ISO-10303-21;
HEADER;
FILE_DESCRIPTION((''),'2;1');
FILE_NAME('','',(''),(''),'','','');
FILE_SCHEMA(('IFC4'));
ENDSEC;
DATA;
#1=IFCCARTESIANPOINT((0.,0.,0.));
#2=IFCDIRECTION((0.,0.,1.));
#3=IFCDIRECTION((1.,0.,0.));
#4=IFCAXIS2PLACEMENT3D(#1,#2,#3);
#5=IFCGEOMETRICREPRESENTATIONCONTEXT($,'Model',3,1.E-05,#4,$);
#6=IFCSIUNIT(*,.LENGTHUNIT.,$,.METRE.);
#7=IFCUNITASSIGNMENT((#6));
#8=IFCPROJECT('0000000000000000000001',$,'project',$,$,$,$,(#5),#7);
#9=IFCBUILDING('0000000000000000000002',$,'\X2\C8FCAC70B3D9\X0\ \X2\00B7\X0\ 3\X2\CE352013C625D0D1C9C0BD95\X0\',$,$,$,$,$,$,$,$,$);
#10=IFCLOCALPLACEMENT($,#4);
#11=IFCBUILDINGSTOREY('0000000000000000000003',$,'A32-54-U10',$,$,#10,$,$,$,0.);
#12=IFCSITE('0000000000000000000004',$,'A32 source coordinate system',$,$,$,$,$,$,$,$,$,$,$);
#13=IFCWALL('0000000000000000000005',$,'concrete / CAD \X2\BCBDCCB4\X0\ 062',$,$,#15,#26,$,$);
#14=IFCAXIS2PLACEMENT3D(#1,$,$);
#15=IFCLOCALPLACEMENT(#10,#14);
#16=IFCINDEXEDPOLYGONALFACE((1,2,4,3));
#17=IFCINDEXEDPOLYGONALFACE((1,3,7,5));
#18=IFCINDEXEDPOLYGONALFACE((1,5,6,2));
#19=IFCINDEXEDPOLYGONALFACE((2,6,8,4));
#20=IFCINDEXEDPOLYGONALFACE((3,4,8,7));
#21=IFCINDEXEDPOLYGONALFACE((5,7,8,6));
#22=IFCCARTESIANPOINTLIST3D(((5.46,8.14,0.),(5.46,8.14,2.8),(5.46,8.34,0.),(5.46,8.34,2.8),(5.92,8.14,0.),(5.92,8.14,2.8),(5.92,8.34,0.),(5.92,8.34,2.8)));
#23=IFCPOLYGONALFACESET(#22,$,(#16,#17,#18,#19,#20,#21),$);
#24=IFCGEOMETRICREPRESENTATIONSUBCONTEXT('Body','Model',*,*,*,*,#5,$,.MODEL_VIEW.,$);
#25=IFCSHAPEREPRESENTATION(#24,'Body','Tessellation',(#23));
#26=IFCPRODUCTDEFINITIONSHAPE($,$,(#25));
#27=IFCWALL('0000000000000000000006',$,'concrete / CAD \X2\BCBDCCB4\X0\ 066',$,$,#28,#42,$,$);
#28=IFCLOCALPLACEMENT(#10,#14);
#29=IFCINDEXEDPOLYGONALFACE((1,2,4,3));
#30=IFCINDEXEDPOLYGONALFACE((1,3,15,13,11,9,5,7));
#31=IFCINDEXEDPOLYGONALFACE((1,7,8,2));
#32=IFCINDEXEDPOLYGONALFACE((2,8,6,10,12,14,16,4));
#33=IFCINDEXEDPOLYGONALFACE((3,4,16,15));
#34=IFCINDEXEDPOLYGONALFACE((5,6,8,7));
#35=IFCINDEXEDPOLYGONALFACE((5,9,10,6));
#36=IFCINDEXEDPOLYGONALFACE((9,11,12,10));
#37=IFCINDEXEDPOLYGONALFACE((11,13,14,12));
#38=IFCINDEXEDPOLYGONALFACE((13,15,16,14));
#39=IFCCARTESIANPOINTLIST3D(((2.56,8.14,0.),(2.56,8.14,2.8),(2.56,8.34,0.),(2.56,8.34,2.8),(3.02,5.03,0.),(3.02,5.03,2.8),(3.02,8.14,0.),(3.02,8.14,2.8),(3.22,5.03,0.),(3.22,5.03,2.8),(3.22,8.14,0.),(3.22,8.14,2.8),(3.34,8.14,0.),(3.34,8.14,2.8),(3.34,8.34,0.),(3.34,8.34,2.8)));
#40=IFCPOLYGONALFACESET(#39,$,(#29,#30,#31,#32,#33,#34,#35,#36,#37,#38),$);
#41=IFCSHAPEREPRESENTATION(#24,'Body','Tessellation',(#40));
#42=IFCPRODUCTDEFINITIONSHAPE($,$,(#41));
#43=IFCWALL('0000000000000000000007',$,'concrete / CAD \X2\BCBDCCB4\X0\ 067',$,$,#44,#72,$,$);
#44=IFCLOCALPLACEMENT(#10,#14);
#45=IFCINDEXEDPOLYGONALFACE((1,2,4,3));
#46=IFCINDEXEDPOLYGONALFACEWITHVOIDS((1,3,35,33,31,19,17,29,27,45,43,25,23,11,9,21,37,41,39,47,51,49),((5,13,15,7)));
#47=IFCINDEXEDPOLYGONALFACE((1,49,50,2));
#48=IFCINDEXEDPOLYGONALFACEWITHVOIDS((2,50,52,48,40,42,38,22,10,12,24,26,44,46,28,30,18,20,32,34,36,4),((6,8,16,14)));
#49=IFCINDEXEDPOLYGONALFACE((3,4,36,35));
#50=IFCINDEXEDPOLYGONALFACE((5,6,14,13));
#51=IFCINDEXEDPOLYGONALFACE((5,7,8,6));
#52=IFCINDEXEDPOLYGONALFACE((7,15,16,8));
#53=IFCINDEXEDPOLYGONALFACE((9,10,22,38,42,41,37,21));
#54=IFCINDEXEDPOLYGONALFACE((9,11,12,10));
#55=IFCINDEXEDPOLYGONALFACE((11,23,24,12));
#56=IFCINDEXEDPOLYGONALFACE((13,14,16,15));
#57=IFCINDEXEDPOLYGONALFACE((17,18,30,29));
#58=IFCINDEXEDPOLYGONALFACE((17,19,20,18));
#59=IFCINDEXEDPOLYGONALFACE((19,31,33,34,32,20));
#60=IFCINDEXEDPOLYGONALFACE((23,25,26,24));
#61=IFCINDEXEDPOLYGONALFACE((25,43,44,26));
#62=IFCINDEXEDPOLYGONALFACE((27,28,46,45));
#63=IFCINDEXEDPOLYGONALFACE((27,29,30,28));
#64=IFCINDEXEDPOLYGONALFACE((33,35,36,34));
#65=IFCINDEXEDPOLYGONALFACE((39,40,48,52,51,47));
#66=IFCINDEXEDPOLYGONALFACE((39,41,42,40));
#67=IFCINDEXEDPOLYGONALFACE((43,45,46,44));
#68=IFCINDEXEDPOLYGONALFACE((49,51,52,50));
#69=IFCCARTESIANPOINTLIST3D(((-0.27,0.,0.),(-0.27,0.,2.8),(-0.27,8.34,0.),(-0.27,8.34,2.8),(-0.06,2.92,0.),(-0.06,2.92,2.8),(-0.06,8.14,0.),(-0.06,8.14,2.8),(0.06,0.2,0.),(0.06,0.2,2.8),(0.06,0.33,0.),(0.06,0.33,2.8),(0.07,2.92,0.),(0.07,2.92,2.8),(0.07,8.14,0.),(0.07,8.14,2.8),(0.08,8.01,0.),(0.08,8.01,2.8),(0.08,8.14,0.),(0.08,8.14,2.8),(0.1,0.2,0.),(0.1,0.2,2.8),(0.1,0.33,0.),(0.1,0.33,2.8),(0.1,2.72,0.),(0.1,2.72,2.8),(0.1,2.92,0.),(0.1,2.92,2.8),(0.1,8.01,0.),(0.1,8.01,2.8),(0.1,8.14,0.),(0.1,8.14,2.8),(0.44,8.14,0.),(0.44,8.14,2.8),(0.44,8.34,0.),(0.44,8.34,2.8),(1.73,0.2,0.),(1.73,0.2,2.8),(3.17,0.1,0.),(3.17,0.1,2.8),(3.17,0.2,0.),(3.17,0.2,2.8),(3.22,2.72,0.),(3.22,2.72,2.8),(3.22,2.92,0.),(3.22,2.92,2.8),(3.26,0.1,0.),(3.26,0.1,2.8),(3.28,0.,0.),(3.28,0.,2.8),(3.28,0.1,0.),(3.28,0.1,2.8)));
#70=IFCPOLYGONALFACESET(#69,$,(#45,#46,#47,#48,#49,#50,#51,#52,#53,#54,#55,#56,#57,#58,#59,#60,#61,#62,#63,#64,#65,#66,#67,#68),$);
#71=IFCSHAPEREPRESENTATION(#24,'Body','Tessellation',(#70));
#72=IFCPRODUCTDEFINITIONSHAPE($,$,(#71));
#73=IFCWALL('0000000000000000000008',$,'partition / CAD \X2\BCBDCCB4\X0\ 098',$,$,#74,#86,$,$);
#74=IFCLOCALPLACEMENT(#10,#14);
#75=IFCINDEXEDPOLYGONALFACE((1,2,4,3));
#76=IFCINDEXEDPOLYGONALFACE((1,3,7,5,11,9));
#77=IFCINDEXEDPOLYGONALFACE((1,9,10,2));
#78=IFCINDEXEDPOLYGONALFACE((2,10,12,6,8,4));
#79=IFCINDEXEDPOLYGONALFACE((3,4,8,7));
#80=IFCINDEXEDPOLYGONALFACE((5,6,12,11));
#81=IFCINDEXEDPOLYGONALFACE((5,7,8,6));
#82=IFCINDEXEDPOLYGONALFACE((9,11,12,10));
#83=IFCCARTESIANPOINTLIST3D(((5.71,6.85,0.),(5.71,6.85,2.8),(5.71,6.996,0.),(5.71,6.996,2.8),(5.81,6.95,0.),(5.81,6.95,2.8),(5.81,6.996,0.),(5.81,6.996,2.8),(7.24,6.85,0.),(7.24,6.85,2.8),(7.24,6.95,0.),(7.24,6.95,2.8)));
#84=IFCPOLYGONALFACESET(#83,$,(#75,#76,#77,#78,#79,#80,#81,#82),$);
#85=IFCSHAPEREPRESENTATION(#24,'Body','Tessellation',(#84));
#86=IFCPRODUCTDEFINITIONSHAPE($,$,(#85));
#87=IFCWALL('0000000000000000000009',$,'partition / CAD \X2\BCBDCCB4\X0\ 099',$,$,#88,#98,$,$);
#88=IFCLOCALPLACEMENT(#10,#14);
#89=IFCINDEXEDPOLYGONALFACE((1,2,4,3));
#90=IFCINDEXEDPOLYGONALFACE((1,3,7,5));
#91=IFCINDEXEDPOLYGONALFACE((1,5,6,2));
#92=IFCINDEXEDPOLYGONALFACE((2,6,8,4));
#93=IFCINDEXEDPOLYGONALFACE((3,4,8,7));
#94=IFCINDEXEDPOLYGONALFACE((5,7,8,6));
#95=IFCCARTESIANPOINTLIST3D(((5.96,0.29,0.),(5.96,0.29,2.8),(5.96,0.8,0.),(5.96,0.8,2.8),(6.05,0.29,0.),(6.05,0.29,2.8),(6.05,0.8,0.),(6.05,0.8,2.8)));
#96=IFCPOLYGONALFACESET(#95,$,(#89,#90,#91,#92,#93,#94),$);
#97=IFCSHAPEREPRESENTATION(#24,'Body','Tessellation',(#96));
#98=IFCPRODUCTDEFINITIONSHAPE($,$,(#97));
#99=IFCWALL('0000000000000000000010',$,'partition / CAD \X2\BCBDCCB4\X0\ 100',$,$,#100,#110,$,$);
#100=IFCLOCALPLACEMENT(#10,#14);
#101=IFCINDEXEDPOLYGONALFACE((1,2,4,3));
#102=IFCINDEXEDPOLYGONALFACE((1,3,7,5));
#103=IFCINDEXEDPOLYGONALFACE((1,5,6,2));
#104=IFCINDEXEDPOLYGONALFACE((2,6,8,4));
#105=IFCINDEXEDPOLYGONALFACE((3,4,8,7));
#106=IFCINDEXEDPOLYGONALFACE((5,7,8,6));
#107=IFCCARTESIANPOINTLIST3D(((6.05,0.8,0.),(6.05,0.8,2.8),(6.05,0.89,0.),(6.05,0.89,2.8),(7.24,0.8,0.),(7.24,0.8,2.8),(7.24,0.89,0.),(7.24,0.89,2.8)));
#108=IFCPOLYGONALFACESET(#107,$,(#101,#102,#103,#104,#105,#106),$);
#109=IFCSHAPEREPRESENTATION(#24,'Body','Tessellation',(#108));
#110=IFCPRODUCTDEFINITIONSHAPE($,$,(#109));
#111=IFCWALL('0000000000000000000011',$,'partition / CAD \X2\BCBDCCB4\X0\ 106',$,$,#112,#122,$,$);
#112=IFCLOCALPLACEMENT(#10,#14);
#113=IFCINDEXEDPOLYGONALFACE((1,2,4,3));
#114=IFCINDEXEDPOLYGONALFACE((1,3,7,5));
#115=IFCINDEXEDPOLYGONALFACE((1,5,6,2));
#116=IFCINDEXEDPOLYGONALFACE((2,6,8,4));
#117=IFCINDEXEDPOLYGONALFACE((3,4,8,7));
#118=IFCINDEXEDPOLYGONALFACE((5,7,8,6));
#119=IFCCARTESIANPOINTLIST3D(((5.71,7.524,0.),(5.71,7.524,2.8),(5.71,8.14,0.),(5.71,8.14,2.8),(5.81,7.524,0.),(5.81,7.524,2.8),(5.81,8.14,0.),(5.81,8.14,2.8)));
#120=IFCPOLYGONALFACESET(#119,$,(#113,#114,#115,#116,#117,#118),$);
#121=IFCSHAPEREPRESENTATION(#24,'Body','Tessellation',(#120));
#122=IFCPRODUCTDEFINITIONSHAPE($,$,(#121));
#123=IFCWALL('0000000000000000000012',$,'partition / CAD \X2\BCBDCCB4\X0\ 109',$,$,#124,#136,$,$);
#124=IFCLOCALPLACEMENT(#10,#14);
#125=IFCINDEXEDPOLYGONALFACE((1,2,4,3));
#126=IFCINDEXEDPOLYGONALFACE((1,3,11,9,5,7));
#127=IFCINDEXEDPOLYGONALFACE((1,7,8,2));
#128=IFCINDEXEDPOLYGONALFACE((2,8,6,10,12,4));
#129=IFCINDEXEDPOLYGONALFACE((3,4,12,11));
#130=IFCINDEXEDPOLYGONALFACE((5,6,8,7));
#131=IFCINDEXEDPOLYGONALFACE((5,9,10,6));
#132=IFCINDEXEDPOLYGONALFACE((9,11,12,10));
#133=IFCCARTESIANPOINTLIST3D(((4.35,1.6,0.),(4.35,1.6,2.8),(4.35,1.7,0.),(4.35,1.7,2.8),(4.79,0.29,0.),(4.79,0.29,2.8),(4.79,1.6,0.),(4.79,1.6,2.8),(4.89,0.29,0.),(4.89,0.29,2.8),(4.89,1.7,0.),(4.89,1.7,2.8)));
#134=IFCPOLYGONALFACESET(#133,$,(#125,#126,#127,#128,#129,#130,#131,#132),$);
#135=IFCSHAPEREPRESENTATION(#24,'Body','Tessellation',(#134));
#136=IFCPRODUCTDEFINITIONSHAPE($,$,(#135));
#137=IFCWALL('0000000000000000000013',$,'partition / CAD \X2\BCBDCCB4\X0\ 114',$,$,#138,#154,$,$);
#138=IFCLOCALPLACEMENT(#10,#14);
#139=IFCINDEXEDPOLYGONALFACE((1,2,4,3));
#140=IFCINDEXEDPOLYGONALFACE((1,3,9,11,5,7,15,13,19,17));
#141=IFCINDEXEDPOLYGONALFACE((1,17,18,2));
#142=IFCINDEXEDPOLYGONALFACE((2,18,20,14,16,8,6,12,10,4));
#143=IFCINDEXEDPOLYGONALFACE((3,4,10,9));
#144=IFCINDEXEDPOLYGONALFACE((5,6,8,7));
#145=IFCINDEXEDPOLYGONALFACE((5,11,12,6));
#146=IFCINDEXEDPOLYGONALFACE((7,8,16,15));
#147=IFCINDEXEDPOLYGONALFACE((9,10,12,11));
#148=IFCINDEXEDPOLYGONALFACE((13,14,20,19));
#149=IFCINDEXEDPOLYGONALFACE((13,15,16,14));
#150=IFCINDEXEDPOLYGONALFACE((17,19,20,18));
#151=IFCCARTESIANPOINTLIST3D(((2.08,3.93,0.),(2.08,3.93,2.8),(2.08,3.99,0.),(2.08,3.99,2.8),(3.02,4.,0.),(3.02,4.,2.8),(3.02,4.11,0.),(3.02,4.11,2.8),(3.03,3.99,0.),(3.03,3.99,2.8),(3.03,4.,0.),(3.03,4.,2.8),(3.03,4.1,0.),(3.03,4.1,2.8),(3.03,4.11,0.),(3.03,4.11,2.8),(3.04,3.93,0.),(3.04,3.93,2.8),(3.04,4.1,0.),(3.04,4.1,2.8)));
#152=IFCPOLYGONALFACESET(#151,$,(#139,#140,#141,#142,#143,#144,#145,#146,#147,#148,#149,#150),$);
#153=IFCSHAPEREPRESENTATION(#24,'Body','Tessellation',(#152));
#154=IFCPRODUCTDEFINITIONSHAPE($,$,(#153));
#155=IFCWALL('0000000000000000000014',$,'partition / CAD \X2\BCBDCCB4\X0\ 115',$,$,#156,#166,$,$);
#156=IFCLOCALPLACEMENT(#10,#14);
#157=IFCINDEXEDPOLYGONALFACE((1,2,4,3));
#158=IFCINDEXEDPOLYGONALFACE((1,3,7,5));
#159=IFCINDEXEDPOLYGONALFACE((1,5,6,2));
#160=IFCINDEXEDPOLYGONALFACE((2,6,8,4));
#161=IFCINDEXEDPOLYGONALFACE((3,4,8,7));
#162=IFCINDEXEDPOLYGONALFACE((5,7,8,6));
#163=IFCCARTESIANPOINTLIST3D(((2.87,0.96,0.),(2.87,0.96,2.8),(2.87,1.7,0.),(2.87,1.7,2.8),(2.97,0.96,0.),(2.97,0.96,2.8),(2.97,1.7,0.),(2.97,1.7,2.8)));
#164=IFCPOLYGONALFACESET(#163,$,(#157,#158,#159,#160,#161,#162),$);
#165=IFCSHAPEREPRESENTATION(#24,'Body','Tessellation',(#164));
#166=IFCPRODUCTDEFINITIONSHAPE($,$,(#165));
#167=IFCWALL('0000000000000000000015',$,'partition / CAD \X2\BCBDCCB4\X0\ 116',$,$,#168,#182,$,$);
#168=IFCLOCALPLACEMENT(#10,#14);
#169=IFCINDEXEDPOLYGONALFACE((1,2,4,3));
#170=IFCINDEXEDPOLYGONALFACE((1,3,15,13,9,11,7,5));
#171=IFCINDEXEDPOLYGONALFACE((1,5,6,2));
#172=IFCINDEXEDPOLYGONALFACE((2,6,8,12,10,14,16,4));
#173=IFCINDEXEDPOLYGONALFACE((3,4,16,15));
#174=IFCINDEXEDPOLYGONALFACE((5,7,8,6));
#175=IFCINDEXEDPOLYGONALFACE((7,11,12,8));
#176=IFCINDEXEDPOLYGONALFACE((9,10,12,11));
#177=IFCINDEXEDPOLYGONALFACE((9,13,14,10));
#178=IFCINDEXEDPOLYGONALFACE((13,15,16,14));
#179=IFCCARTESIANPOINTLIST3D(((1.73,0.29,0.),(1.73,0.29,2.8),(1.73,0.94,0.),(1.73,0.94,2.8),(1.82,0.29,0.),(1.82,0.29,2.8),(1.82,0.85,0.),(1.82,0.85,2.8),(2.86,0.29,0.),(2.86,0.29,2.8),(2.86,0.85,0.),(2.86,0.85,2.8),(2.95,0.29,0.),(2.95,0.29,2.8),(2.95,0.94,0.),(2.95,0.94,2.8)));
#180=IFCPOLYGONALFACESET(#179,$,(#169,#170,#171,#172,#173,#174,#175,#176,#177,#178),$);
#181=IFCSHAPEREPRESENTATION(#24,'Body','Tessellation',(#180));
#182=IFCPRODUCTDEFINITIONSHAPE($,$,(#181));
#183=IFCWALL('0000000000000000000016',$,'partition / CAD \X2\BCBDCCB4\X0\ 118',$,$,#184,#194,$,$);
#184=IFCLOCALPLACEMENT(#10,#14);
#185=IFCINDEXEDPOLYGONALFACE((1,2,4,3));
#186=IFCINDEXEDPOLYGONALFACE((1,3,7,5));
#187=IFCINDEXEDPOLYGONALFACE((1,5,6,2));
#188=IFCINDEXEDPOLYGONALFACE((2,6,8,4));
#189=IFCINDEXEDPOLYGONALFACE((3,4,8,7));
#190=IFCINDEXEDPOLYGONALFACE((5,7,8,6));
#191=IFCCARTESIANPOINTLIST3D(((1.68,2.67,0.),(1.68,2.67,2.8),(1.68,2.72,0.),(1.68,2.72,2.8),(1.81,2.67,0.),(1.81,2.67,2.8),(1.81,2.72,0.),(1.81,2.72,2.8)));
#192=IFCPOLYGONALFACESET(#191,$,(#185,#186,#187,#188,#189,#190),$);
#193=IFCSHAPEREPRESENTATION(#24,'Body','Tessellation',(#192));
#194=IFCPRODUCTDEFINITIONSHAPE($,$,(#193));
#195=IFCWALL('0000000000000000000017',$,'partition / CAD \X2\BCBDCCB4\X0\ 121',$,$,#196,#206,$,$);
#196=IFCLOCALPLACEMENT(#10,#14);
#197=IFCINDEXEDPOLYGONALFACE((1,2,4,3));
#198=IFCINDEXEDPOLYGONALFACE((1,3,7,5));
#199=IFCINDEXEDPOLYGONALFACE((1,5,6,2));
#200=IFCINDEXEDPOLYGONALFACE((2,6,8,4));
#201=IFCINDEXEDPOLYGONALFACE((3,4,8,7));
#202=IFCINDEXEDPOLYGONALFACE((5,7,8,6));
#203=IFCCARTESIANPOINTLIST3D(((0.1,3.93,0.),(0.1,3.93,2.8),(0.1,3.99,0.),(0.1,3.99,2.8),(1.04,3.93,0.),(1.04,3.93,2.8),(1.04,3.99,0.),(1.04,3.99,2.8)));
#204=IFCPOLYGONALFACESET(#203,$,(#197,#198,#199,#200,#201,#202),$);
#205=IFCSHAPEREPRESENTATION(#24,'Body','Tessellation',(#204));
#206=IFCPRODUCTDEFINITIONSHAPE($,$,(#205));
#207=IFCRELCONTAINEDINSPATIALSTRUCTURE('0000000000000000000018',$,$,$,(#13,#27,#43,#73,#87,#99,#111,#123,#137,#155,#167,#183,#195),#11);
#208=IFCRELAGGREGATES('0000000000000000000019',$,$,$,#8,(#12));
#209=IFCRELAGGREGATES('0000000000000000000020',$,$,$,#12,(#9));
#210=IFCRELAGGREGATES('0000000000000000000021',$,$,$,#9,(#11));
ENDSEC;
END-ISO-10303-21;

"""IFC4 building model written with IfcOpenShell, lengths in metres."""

from ifc_helpers import new_model, si_unit, origin, origin_with_axes, place, context, subcontext, project, spatial, polyline, outline, extrude, element, save


model = new_model("IFC4")

# Units and contexts
model_context = context("Model", 3, precision=1e-05, world=origin_with_axes())
body_context = subcontext(model_context, "Body", "Model", "MODEL_VIEW")
ifc_project = project(units=[si_unit("LENGTHUNIT", "METRE")], contexts=[model_context])

# Site, building, storey
site = spatial("IfcSite", under=ifc_project, Name="A32 source coordinate system")
building = spatial("IfcBuilding", under=site, Name="주거동 · 3층–옥탑지붕")
storey_placement = place(None, origin_with_axes())
storey = spatial("IfcBuildingStorey", under=building, at=storey_placement, Name="A32-54-U10", Elevation=0.0)

# Walls
wall_1_placement = place(storey_placement, origin_with_axes())
element("IfcWall", 1, at=wall_1_placement, inside=storey, Name="concrete / CAD 벽체 062", context=body_context, shape_type="SweptSolid", body=[
    extrude(outline(polyline([(5.46, 8.14), (5.46, 8.34), (5.92, 8.34), (5.92, 8.14), (5.46, 8.14)])), origin(), (0.0, 0.0, 1.0), 2.8),
])
wall_2_placement = place(storey_placement, origin_with_axes())
element("IfcWall", 2, at=wall_2_placement, inside=storey, Name="concrete / CAD 벽체 066", context=body_context, shape_type="SweptSolid", body=[
    extrude(outline(polyline([(3.22, 8.14), (3.22, 5.03), (3.02, 5.03), (3.02, 8.14), (2.56, 8.14), (2.56, 8.34), (3.34, 8.34), (3.34, 8.14), (3.22, 8.14)])), origin(), (0.0, 0.0, 1.0), 2.8),
])
wall_3_placement = place(storey_placement, origin_with_axes())
element("IfcWall", 3, at=wall_3_placement, inside=storey, Name="concrete / CAD 벽체 067", context=body_context, shape_type="SweptSolid", body=[
    extrude(outline(polyline([(0.1, 0.2), (1.73, 0.2), (3.17, 0.2), (3.17, 0.1), (3.26, 0.1), (3.28, 0.1), (3.28, 0.0), (-0.27, 0.0), (-0.27, 8.34), (0.44, 8.34), (0.44, 8.14), (0.1, 8.14), (0.08, 8.14), (0.08, 8.01), (0.1, 8.01), (0.1, 2.92), (3.22, 2.92), (3.22, 2.72), (0.1, 2.72), (0.1, 0.33), (0.06, 0.33), (0.06, 0.2), (0.1, 0.2)]), holes=[polyline([(-0.06, 8.14), (-0.06, 2.92), (0.07, 2.92), (0.07, 8.14), (-0.06, 8.14)])]), origin(), (0.0, 0.0, 1.0), 2.8),
])
wall_4_placement = place(storey_placement, origin_with_axes())
element("IfcWall", 4, at=wall_4_placement, inside=storey, Name="partition / CAD 벽체 098", context=body_context, shape_type="SweptSolid", body=[
    extrude(outline(polyline([(5.71, 6.996), (5.81, 6.996), (5.81, 6.95), (7.24, 6.95), (7.24, 6.85), (5.71, 6.85), (5.71, 6.996)])), origin(), (0.0, 0.0, 1.0), 2.8),
])
wall_5_placement = place(storey_placement, origin_with_axes())
element("IfcWall", 5, at=wall_5_placement, inside=storey, Name="partition / CAD 벽체 099", context=body_context, shape_type="SweptSolid", body=[
    extrude(outline(polyline([(6.05, 0.8), (6.05, 0.29), (5.96, 0.29), (5.96, 0.8), (6.05, 0.8)])), origin(), (0.0, 0.0, 1.0), 2.8),
])
wall_6_placement = place(storey_placement, origin_with_axes())
element("IfcWall", 6, at=wall_6_placement, inside=storey, Name="partition / CAD 벽체 100", context=body_context, shape_type="SweptSolid", body=[
    extrude(outline(polyline([(7.24, 0.8), (6.05, 0.8), (6.05, 0.89), (7.24, 0.89), (7.24, 0.8)])), origin(), (0.0, 0.0, 1.0), 2.8),
])
wall_7_placement = place(storey_placement, origin_with_axes())
element("IfcWall", 7, at=wall_7_placement, inside=storey, Name="partition / CAD 벽체 106", context=body_context, shape_type="SweptSolid", body=[
    extrude(outline(polyline([(5.71, 8.14), (5.81, 8.14), (5.81, 7.524), (5.71, 7.524), (5.71, 8.14)])), origin(), (0.0, 0.0, 1.0), 2.8),
])
wall_8_placement = place(storey_placement, origin_with_axes())
element("IfcWall", 8, at=wall_8_placement, inside=storey, Name="partition / CAD 벽체 109", context=body_context, shape_type="SweptSolid", body=[
    extrude(outline(polyline([(4.79, 1.6), (4.35, 1.6), (4.35, 1.7), (4.89, 1.7), (4.89, 0.29), (4.79, 0.29), (4.79, 1.6)])), origin(), (0.0, 0.0, 1.0), 2.8),
])
wall_9_placement = place(storey_placement, origin_with_axes())
element("IfcWall", 9, at=wall_9_placement, inside=storey, Name="partition / CAD 벽체 114", context=body_context, shape_type="SweptSolid", body=[
    extrude(outline(polyline([(2.08, 3.99), (3.03, 3.99), (3.03, 4.0), (3.02, 4.0), (3.02, 4.11), (3.03, 4.11), (3.03, 4.1), (3.04, 4.1), (3.04, 3.93), (2.08, 3.93), (2.08, 3.99)])), origin(), (0.0, 0.0, 1.0), 2.8),
])
wall_10_placement = place(storey_placement, origin_with_axes())
element("IfcWall", 10, at=wall_10_placement, inside=storey, Name="partition / CAD 벽체 115", context=body_context, shape_type="SweptSolid", body=[
    extrude(outline(polyline([(2.87, 1.7), (2.97, 1.7), (2.97, 0.96), (2.87, 0.96), (2.87, 1.7)])), origin(), (0.0, 0.0, 1.0), 2.8),
])
wall_11_placement = place(storey_placement, origin_with_axes())
element("IfcWall", 11, at=wall_11_placement, inside=storey, Name="partition / CAD 벽체 116", context=body_context, shape_type="SweptSolid", body=[
    extrude(outline(polyline([(2.95, 0.29), (2.86, 0.29), (2.86, 0.85), (1.82, 0.85), (1.82, 0.29), (1.73, 0.29), (1.73, 0.94), (2.95, 0.94), (2.95, 0.29)])), origin(), (0.0, 0.0, 1.0), 2.8),
])
wall_12_placement = place(storey_placement, origin_with_axes())
element("IfcWall", 12, at=wall_12_placement, inside=storey, Name="partition / CAD 벽체 118", context=body_context, shape_type="SweptSolid", body=[
    extrude(outline(polyline([(1.81, 2.67), (1.68, 2.67), (1.68, 2.72), (1.81, 2.72), (1.81, 2.67)])), origin(), (0.0, 0.0, 1.0), 2.8),
])
wall_13_placement = place(storey_placement, origin_with_axes())
element("IfcWall", 13, at=wall_13_placement, inside=storey, Name="partition / CAD 벽체 121", context=body_context, shape_type="SweptSolid", body=[
    extrude(outline(polyline([(0.1, 3.99), (1.04, 3.99), (1.04, 3.93), (0.1, 3.93), (0.1, 3.99)])), origin(), (0.0, 0.0, 1.0), 2.8),
])

save(model, "model.ifc")
